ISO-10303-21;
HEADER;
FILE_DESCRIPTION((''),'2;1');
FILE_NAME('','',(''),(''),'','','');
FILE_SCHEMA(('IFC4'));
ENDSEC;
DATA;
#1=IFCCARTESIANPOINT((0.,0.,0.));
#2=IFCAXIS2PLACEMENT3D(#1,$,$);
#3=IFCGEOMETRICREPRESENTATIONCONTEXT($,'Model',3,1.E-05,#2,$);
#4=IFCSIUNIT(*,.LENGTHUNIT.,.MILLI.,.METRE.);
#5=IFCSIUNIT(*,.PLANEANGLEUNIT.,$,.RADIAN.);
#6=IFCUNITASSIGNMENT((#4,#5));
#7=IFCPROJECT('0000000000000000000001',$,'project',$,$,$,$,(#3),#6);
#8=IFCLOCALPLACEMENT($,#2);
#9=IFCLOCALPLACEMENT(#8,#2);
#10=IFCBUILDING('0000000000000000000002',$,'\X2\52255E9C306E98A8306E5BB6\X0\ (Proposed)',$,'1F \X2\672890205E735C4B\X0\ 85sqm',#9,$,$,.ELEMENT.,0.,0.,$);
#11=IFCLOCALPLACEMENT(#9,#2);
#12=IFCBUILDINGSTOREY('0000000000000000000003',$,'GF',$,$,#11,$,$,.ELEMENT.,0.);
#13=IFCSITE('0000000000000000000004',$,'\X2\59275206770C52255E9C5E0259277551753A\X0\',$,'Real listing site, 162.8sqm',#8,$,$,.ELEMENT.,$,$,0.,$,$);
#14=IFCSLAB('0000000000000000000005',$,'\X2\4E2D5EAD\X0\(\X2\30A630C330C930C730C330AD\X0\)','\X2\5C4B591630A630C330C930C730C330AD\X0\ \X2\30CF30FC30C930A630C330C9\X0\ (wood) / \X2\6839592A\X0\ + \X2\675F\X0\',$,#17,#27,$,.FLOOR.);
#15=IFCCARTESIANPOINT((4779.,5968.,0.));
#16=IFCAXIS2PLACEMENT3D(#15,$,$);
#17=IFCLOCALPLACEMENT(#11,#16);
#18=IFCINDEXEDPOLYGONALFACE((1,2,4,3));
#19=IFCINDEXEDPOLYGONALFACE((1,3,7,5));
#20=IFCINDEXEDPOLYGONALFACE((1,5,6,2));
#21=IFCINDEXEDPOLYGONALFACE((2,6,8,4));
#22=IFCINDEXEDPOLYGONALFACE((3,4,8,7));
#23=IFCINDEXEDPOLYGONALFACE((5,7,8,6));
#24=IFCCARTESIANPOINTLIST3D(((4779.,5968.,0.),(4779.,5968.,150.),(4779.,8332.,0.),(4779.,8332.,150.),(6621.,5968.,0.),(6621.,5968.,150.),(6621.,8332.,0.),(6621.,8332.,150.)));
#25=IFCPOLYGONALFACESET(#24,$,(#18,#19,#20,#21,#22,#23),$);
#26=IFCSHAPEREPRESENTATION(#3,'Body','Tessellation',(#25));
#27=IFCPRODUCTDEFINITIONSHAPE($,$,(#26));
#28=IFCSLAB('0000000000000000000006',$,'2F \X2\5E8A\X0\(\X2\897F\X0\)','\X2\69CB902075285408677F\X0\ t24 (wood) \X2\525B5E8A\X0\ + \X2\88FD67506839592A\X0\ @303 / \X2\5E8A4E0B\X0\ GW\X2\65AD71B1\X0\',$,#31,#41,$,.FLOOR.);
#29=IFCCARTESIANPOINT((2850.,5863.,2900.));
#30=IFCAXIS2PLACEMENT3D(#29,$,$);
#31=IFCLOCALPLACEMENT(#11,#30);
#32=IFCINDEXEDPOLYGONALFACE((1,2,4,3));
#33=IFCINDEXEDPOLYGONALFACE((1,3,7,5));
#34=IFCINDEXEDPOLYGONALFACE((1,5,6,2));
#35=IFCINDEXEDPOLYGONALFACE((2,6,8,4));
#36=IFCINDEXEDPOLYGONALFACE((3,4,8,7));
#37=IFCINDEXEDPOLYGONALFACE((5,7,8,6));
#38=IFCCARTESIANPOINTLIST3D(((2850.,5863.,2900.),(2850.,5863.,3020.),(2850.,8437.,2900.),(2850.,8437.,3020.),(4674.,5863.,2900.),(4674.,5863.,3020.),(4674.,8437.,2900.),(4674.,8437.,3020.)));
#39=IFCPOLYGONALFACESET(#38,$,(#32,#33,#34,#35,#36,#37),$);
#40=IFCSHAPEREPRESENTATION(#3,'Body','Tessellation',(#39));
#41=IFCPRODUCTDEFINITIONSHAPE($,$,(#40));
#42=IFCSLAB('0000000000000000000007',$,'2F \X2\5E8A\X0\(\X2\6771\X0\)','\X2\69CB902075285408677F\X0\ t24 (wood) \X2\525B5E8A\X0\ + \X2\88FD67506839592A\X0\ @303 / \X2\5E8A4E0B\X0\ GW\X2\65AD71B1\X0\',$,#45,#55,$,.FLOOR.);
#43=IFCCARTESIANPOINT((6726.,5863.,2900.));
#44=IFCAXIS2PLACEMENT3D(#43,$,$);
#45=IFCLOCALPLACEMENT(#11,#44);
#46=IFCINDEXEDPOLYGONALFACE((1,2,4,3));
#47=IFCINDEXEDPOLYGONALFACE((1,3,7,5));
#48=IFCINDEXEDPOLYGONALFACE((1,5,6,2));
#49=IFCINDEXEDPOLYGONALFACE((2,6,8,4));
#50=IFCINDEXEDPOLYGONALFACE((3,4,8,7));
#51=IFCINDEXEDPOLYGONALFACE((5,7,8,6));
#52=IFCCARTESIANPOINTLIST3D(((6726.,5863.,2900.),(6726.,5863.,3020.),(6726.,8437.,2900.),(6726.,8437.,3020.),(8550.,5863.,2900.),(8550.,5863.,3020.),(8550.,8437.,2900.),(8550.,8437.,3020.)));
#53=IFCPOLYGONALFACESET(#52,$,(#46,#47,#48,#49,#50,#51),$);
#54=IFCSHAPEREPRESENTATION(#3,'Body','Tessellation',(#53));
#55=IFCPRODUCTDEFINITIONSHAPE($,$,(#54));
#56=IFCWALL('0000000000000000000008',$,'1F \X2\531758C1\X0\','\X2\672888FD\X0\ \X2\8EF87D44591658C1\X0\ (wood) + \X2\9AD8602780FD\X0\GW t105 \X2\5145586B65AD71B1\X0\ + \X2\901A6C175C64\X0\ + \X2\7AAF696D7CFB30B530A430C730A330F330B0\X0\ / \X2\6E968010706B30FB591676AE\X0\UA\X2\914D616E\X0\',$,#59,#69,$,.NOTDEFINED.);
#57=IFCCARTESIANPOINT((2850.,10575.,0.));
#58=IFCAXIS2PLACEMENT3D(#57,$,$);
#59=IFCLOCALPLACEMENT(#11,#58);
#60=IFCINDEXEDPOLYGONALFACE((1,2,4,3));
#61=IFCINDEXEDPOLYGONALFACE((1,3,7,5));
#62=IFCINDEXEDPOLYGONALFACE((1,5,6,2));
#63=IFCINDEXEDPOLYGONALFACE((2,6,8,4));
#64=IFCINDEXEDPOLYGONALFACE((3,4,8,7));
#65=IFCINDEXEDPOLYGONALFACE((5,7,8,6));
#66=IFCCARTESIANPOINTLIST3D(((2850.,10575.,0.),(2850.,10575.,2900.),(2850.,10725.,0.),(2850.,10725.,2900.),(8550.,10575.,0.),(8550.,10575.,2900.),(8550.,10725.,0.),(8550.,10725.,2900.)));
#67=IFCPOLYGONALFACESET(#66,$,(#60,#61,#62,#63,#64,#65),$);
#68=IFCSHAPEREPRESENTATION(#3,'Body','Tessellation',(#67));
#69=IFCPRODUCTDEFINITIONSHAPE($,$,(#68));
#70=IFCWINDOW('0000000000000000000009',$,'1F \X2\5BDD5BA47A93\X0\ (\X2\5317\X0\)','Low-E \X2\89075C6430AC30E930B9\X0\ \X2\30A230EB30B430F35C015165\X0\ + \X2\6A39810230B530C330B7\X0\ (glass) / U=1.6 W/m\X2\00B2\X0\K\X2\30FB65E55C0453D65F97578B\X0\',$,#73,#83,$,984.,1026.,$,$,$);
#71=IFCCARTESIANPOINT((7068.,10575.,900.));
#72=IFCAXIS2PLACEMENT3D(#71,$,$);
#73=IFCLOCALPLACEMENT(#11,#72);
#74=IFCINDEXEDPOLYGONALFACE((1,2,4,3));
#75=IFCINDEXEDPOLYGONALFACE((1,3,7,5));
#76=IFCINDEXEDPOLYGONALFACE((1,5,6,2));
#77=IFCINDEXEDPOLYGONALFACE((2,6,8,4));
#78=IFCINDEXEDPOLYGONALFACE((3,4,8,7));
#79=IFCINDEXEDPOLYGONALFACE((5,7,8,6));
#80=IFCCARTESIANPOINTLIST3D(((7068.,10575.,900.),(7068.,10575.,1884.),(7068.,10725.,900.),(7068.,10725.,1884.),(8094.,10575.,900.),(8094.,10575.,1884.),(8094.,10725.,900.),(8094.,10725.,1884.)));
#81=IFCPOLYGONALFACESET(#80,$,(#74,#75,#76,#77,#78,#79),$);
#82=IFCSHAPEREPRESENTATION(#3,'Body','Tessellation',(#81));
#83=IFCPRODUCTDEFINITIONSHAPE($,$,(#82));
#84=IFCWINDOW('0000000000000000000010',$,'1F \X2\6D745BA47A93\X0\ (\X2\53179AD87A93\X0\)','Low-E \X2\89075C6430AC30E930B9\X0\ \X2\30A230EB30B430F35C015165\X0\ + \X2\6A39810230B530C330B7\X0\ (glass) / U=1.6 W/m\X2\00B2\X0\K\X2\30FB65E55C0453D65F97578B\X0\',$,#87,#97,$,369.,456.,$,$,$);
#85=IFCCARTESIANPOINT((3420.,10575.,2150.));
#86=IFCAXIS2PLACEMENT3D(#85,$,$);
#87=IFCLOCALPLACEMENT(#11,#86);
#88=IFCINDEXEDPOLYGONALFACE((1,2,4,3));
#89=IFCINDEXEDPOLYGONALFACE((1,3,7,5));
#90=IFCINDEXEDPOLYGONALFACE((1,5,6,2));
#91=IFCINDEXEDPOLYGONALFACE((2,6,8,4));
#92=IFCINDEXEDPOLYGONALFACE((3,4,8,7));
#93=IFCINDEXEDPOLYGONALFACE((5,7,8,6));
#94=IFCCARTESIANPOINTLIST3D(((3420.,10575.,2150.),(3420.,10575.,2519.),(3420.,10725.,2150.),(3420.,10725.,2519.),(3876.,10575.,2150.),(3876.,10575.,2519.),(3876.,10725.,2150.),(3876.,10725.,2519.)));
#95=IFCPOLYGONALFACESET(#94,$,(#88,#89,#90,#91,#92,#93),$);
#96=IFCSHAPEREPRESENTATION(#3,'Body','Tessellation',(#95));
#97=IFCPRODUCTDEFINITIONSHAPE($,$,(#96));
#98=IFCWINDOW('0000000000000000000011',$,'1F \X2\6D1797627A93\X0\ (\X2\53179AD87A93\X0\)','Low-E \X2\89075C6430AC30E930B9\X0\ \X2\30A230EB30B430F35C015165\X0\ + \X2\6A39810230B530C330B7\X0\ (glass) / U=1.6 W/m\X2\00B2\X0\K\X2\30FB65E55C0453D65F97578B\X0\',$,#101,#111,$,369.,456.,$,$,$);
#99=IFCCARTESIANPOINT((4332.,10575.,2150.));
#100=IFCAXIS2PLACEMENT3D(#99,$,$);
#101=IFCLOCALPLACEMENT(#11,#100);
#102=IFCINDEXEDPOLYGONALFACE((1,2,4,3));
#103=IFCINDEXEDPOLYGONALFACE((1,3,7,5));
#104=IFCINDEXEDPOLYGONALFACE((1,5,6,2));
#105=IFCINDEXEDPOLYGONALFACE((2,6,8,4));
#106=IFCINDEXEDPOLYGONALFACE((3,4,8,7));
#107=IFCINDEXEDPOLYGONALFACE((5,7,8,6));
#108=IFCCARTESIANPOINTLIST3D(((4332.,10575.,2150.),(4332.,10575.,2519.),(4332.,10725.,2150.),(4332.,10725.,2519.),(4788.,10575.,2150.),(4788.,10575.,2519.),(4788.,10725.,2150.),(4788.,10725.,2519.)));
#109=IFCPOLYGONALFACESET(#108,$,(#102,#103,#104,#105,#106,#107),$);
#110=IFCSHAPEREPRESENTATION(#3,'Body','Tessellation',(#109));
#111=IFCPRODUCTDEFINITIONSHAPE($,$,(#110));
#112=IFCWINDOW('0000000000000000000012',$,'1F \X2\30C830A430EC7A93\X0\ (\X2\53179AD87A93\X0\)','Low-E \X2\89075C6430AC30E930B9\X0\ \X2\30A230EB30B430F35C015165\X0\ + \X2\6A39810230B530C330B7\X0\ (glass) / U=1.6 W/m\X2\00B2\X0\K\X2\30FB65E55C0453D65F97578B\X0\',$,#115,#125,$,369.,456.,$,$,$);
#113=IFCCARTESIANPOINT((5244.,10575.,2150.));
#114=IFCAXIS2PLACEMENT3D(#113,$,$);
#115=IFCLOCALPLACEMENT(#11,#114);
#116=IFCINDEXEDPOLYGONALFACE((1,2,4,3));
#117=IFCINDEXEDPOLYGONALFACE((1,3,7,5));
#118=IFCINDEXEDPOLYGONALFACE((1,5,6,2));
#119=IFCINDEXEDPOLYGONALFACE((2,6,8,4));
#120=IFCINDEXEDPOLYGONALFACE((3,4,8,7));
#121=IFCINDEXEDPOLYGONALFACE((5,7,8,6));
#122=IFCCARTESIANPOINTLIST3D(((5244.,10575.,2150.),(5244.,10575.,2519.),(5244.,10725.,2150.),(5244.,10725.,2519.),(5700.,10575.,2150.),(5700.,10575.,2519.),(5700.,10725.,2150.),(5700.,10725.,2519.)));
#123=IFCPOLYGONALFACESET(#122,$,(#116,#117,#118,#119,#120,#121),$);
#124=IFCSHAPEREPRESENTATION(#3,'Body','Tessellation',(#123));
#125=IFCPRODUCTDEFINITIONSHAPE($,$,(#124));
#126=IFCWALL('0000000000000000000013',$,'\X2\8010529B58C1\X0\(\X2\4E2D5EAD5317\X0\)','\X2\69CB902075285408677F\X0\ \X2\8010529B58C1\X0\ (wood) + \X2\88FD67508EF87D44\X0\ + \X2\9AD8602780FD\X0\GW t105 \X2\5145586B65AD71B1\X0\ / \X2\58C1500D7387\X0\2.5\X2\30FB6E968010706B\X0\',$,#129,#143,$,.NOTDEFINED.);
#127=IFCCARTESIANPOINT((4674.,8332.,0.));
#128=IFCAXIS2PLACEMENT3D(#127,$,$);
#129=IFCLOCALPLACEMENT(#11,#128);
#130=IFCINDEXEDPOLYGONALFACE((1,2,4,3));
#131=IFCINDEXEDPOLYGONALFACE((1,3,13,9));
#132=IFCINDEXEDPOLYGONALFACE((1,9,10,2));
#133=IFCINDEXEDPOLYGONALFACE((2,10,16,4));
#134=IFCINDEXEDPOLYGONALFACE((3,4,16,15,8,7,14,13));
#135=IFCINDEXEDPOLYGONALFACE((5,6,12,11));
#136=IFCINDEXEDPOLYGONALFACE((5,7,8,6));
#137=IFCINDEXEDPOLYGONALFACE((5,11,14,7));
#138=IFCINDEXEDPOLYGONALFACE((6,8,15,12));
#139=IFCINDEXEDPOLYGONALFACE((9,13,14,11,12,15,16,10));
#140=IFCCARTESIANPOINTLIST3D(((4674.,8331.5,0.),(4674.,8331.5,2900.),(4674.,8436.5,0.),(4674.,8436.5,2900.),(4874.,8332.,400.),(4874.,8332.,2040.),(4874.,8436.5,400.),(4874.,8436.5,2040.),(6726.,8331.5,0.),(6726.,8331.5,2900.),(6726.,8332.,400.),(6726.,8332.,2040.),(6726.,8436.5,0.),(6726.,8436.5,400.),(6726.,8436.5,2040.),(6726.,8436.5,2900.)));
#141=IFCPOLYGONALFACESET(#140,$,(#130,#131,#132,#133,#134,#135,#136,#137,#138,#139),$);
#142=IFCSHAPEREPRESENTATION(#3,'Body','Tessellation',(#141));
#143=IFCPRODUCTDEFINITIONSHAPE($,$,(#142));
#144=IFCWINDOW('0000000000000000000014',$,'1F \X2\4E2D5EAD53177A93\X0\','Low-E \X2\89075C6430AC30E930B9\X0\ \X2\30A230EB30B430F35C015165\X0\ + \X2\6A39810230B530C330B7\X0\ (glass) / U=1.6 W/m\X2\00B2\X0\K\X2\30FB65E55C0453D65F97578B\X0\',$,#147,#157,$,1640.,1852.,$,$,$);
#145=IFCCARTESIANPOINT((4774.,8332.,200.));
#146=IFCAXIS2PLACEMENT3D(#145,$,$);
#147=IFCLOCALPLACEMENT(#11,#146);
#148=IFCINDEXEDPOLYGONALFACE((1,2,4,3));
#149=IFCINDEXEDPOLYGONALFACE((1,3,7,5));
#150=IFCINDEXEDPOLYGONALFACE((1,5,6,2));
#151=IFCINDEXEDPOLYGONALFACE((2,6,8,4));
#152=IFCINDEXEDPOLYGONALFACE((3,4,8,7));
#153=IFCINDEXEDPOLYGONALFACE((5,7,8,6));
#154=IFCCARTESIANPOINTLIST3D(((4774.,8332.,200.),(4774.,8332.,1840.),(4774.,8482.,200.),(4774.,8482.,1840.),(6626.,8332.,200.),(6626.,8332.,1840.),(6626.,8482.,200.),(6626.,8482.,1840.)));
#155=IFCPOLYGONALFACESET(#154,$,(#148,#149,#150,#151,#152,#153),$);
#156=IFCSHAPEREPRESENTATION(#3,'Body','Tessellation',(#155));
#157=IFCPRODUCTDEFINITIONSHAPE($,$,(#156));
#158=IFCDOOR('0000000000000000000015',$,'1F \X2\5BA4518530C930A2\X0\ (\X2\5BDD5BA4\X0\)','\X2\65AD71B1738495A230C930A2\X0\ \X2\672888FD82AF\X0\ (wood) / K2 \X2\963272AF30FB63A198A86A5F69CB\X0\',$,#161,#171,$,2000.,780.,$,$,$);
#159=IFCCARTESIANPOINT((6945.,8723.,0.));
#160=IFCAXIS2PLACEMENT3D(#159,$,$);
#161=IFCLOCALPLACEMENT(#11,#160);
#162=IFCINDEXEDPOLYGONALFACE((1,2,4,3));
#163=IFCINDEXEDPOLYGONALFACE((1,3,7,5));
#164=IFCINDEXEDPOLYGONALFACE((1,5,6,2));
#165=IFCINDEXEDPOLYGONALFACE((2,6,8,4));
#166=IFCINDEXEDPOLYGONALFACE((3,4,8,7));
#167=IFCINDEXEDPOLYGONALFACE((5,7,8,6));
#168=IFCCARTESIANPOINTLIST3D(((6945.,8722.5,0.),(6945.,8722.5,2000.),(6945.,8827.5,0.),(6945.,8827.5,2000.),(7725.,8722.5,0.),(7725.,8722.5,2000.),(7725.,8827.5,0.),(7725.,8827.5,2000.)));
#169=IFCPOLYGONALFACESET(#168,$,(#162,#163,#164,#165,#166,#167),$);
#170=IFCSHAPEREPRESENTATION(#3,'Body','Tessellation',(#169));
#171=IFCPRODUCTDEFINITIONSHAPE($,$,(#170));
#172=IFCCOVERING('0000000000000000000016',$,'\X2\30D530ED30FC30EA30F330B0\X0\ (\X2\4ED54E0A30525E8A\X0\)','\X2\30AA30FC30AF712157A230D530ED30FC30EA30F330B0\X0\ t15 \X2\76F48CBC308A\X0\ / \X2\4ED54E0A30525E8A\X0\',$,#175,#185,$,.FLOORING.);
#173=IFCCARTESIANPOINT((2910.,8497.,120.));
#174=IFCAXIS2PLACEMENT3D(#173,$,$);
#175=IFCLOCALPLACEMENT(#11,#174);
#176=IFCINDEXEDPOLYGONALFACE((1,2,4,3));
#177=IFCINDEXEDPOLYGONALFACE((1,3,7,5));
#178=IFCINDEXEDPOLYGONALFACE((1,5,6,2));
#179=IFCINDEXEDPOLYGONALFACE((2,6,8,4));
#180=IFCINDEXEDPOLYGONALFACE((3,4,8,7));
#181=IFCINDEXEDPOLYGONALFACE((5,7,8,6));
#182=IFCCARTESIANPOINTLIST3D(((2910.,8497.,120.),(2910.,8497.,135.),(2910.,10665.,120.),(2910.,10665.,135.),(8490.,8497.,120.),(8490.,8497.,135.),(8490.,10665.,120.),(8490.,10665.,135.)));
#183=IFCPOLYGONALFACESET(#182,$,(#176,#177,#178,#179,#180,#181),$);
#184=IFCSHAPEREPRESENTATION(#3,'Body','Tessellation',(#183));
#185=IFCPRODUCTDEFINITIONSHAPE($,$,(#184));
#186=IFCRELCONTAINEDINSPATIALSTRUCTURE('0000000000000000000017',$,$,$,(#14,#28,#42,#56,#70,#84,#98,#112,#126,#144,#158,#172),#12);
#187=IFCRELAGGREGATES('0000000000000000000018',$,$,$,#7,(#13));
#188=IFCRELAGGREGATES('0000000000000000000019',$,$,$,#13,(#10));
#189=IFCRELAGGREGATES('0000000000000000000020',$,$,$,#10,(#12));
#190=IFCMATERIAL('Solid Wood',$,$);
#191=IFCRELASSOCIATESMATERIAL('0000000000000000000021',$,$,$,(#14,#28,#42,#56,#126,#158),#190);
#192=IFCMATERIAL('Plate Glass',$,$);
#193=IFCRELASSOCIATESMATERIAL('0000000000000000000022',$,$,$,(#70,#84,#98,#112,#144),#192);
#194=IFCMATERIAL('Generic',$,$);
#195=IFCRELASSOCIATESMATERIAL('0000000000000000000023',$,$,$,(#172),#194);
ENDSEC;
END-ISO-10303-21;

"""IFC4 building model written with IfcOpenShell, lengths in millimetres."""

from ifc_helpers import new_model, si_unit, frame, frame_2d, origin, place, context, project, spatial, rectangle, extrude, material, element, fill, save


model = new_model("IFC4")

# Units and contexts
model_context = context("Model", 3, precision=1e-05, world=origin())
ifc_project = project(units=[si_unit("LENGTHUNIT", "METRE", prefix="MILLI"), si_unit("PLANEANGLEUNIT", "RADIAN")], contexts=[model_context])

# Site, building, storey
site_placement = place(None, origin())
site = spatial("IfcSite", under=ifc_project, at=site_placement, Name="大分県別府市大畑町", ObjectType="Real listing site, 162.8sqm", CompositionType="ELEMENT", RefElevation=0.0)
building_placement = place(site_placement, origin())
building = spatial("IfcBuilding", under=site, at=building_placement, Name="別府の風の家 (Proposed)", ObjectType="1F 木造平屋 85sqm", CompositionType="ELEMENT", ElevationOfRefHeight=0.0, ElevationOfTerrain=0.0)
storey_placement = place(building_placement, origin())
storey = spatial("IfcBuildingStorey", under=building, at=storey_placement, Name="GF", CompositionType="ELEMENT", Elevation=0.0)

# Slabs
ifc_material_1 = material(Name="Solid Wood")
slab_1_placement = place(storey_placement, frame((4779.0, 5968.0, 0.0)))
element("IfcSlab", 1, at=slab_1_placement, inside=storey, material=ifc_material_1, Name="中庭(ウッドデッキ)", Description="屋外ウッドデッキ ハードウッド (wood) / 根太 + 束", PredefinedType="FLOOR", context=model_context, shape_type="SweptSolid", body=[
    extrude(rectangle(XDim=1842.0, YDim=2364.0, at=frame_2d((921.0, 1182.0))), frame((4779.0, 5968.0, 0.0)), (0.0, 0.0, 1.0), 150.0),
])
slab_2_placement = place(storey_placement, frame((2850.0, 5863.0, 2900.0)))
element("IfcSlab", 2, at=slab_2_placement, inside=storey, material=ifc_material_1, Name="2F 床(西)", Description="構造用合板 t24 (wood) 剛床 + 製材根太 @303 / 床下 GW断熱", PredefinedType="FLOOR", context=model_context, shape_type="SweptSolid", body=[
    extrude(rectangle(XDim=1824.0, YDim=2574.0, at=frame_2d((912.0, 1287.0))), frame((2850.0, 5863.0, 2900.0)), (0.0, 0.0, 1.0), 120.0),
])
slab_3_placement = place(storey_placement, frame((6726.0, 5863.0, 2900.0)))
element("IfcSlab", 3, at=slab_3_placement, inside=storey, material=ifc_material_1, Name="2F 床(東)", Description="構造用合板 t24 (wood) 剛床 + 製材根太 @303 / 床下 GW断熱", PredefinedType="FLOOR", context=model_context, shape_type="SweptSolid", body=[
    extrude(rectangle(XDim=1824.0, YDim=2574.0, at=frame_2d((912.0, 1287.0))), frame((6726.0, 5863.0, 2900.0)), (0.0, 0.0, 1.0), 120.0),
])

# Wall, openings, windows
wall_1_placement = place(storey_placement, frame((2850.0, 10575.0, 0.0)))
wall_1 = element("IfcWall", 4, at=wall_1_placement, inside=storey, material=ifc_material_1, Name="1F 北壁", Description="木製 軸組外壁 (wood) + 高性能GW t105 充填断熱 + 通気層 + 窯業系サイディング / 準耐火・外皮UA配慮", PredefinedType="NOTDEFINED", context=model_context, shape_type="SweptSolid", body=[
    extrude(rectangle(XDim=5700.0, YDim=150.0, at=frame_2d((2850.0, 75.0))), frame((2850.0, 10575.0, 0.0)), (0.0, 0.0, 1.0), 2900.0),
])
opening_1_placement = place(storey_placement, frame((7068.0, 10575.0, 900.0)))
opening_1 = element("IfcOpeningElement", 5, at=opening_1_placement, cuts=wall_1, PredefinedType="NOTDEFINED", context=model_context, shape_type="SweptSolid", body=[
    extrude(rectangle(XDim=1026.0, YDim=150.0, at=frame_2d((513.0, 75.0))), frame((7068.0, 10575.0, 900.0)), (0.0, 0.0, 1.0), 984.0),
])
opening_2_placement = place(storey_placement, frame((3420.0, 10575.0, 2150.0)))
opening_2 = element("IfcOpeningElement", 6, at=opening_2_placement, cuts=wall_1, PredefinedType="NOTDEFINED", context=model_context, shape_type="SweptSolid", body=[
    extrude(rectangle(XDim=456.0, YDim=150.0, at=frame_2d((228.0, 75.0))), frame((3420.0, 10575.0, 2150.0)), (0.0, 0.0, 1.0), 369.0),
])
opening_3_placement = place(storey_placement, frame((4332.0, 10575.0, 2150.0)))
opening_3 = element("IfcOpeningElement", 7, at=opening_3_placement, cuts=wall_1, PredefinedType="NOTDEFINED", context=model_context, shape_type="SweptSolid", body=[
    extrude(rectangle(XDim=456.0, YDim=150.0, at=frame_2d((228.0, 75.0))), frame((4332.0, 10575.0, 2150.0)), (0.0, 0.0, 1.0), 369.0),
])
opening_4_placement = place(storey_placement, frame((5244.0, 10575.0, 2150.0)))
opening_4 = element("IfcOpeningElement", 8, at=opening_4_placement, cuts=wall_1, PredefinedType="NOTDEFINED", context=model_context, shape_type="SweptSolid", body=[
    extrude(rectangle(XDim=456.0, YDim=150.0, at=frame_2d((228.0, 75.0))), frame((5244.0, 10575.0, 2150.0)), (0.0, 0.0, 1.0), 369.0),
])
ifc_material_2 = material(Name="Plate Glass")
window_1_placement = place(storey_placement, frame((7068.0, 10575.0, 900.0)))
window_1 = element("IfcWindow", 9, at=window_1_placement, inside=storey, material=ifc_material_2, Name="1F 寝室窓 (北)", Description="Low-E 複層ガラス アルゴン封入 + 樹脂サッシ (glass) / U=1.6 W/m²K・日射取得型", OverallHeight=984.0, OverallWidth=1026.0, context=model_context, shape_type="SweptSolid", body=[
    extrude(rectangle(XDim=1026.0, YDim=150.0, at=frame_2d((513.0, 75.0))), frame((7068.0, 10575.0, 900.0)), (0.0, 0.0, 1.0), 984.0),
])
fill(opening_1, window_1)
window_2_placement = place(storey_placement, frame((3420.0, 10575.0, 2150.0)))
window_2 = element("IfcWindow", 10, at=window_2_placement, inside=storey, material=ifc_material_2, Name="1F 浴室窓 (北高窓)", Description="Low-E 複層ガラス アルゴン封入 + 樹脂サッシ (glass) / U=1.6 W/m²K・日射取得型", OverallHeight=369.0, OverallWidth=456.0, context=model_context, shape_type="SweptSolid", body=[
    extrude(rectangle(XDim=456.0, YDim=150.0, at=frame_2d((228.0, 75.0))), frame((3420.0, 10575.0, 2150.0)), (0.0, 0.0, 1.0), 369.0),
])
fill(opening_2, window_2)
window_3_placement = place(storey_placement, frame((4332.0, 10575.0, 2150.0)))
window_3 = element("IfcWindow", 11, at=window_3_placement, inside=storey, material=ifc_material_2, Name="1F 洗面窓 (北高窓)", Description="Low-E 複層ガラス アルゴン封入 + 樹脂サッシ (glass) / U=1.6 W/m²K・日射取得型", OverallHeight=369.0, OverallWidth=456.0, context=model_context, shape_type="SweptSolid", body=[
    extrude(rectangle(XDim=456.0, YDim=150.0, at=frame_2d((228.0, 75.0))), frame((4332.0, 10575.0, 2150.0)), (0.0, 0.0, 1.0), 369.0),
])
fill(opening_3, window_3)
window_4_placement = place(storey_placement, frame((5244.0, 10575.0, 2150.0)))
window_4 = element("IfcWindow", 12, at=window_4_placement, inside=storey, material=ifc_material_2, Name="1F トイレ窓 (北高窓)", Description="Low-E 複層ガラス アルゴン封入 + 樹脂サッシ (glass) / U=1.6 W/m²K・日射取得型", OverallHeight=369.0, OverallWidth=456.0, context=model_context, shape_type="SweptSolid", body=[
    extrude(rectangle(XDim=456.0, YDim=150.0, at=frame_2d((228.0, 75.0))), frame((5244.0, 10575.0, 2150.0)), (0.0, 0.0, 1.0), 369.0),
])
fill(opening_4, window_4)

# Wall, opening, window
wall_2_placement = place(storey_placement, frame((4674.0, 8332.0, 0.0)))
wall_2 = element("IfcWall", 13, at=wall_2_placement, inside=storey, material=ifc_material_1, Name="耐力壁(中庭北)", Description="構造用合板 耐力壁 (wood) + 製材軸組 + 高性能GW t105 充填断熱 / 壁倍率2.5・準耐火", PredefinedType="NOTDEFINED", context=model_context, shape_type="SweptSolid", body=[
    extrude(rectangle(XDim=2052.0, YDim=105.0, at=frame_2d((1026.0, 52.0))), frame((4674.0, 8332.0, 0.0)), (0.0, 0.0, 1.0), 2900.0),
])
opening_5_placement = place(storey_placement, frame((4774.0, 8332.0, 200.0)))
opening_5 = element("IfcOpeningElement", 14, at=opening_5_placement, cuts=wall_2, PredefinedType="NOTDEFINED", context=model_context, shape_type="SweptSolid", body=[
    extrude(rectangle(XDim=1852.0, YDim=150.0, at=frame_2d((926.0, 75.0))), frame((4774.0, 8332.0, 200.0)), (0.0, 0.0, 1.0), 1640.0),
])
window_5_placement = place(storey_placement, frame((4774.0, 8332.0, 200.0)))
window_5 = element("IfcWindow", 15, at=window_5_placement, inside=storey, material=ifc_material_2, Name="1F 中庭北窓", Description="Low-E 複層ガラス アルゴン封入 + 樹脂サッシ (glass) / U=1.6 W/m²K・日射取得型", OverallHeight=1640.0, OverallWidth=1852.0, context=model_context, shape_type="SweptSolid", body=[
    extrude(rectangle(XDim=1852.0, YDim=150.0, at=frame_2d((926.0, 75.0))), frame((4774.0, 8332.0, 200.0)), (0.0, 0.0, 1.0), 1640.0),
])
fill(opening_5, window_5)

# Door
door_1_placement = place(storey_placement, frame((6945.0, 8723.0, 0.0)))
element("IfcDoor", 16, at=door_1_placement, inside=storey, material=ifc_material_1, Name="1F 室内ドア (寝室)", Description="断熱玄関ドア 木製芯 (wood) / K2 防犯・採風機構", OverallHeight=2000.0, OverallWidth=780.0, context=model_context, shape_type="SweptSolid", body=[
    extrude(rectangle(XDim=780.0, YDim=105.0, at=frame_2d((390.0, 52.0))), frame((6945.0, 8723.0, 0.0)), (0.0, 0.0, 1.0), 2000.0),
])

# Covering
ifc_material_3 = material(Name="Generic")
covering_1_placement = place(storey_placement, frame((2910.0, 8497.0, 120.0)))
element("IfcCovering", 17, at=covering_1_placement, inside=storey, material=ifc_material_3, Name="フローリング (仕上げ床)", Description="オーク無垢フローリング t15 直貼り / 仕上げ床", PredefinedType="FLOORING", context=model_context, shape_type="SweptSolid", body=[
    extrude(rectangle(XDim=5580.0, YDim=2168.0, at=frame_2d((2790.0, 1084.0))), frame((2910.0, 8497.0, 120.0)), (0.0, 0.0, 1.0), 15.0),
])

save(model, "model.ifc")
